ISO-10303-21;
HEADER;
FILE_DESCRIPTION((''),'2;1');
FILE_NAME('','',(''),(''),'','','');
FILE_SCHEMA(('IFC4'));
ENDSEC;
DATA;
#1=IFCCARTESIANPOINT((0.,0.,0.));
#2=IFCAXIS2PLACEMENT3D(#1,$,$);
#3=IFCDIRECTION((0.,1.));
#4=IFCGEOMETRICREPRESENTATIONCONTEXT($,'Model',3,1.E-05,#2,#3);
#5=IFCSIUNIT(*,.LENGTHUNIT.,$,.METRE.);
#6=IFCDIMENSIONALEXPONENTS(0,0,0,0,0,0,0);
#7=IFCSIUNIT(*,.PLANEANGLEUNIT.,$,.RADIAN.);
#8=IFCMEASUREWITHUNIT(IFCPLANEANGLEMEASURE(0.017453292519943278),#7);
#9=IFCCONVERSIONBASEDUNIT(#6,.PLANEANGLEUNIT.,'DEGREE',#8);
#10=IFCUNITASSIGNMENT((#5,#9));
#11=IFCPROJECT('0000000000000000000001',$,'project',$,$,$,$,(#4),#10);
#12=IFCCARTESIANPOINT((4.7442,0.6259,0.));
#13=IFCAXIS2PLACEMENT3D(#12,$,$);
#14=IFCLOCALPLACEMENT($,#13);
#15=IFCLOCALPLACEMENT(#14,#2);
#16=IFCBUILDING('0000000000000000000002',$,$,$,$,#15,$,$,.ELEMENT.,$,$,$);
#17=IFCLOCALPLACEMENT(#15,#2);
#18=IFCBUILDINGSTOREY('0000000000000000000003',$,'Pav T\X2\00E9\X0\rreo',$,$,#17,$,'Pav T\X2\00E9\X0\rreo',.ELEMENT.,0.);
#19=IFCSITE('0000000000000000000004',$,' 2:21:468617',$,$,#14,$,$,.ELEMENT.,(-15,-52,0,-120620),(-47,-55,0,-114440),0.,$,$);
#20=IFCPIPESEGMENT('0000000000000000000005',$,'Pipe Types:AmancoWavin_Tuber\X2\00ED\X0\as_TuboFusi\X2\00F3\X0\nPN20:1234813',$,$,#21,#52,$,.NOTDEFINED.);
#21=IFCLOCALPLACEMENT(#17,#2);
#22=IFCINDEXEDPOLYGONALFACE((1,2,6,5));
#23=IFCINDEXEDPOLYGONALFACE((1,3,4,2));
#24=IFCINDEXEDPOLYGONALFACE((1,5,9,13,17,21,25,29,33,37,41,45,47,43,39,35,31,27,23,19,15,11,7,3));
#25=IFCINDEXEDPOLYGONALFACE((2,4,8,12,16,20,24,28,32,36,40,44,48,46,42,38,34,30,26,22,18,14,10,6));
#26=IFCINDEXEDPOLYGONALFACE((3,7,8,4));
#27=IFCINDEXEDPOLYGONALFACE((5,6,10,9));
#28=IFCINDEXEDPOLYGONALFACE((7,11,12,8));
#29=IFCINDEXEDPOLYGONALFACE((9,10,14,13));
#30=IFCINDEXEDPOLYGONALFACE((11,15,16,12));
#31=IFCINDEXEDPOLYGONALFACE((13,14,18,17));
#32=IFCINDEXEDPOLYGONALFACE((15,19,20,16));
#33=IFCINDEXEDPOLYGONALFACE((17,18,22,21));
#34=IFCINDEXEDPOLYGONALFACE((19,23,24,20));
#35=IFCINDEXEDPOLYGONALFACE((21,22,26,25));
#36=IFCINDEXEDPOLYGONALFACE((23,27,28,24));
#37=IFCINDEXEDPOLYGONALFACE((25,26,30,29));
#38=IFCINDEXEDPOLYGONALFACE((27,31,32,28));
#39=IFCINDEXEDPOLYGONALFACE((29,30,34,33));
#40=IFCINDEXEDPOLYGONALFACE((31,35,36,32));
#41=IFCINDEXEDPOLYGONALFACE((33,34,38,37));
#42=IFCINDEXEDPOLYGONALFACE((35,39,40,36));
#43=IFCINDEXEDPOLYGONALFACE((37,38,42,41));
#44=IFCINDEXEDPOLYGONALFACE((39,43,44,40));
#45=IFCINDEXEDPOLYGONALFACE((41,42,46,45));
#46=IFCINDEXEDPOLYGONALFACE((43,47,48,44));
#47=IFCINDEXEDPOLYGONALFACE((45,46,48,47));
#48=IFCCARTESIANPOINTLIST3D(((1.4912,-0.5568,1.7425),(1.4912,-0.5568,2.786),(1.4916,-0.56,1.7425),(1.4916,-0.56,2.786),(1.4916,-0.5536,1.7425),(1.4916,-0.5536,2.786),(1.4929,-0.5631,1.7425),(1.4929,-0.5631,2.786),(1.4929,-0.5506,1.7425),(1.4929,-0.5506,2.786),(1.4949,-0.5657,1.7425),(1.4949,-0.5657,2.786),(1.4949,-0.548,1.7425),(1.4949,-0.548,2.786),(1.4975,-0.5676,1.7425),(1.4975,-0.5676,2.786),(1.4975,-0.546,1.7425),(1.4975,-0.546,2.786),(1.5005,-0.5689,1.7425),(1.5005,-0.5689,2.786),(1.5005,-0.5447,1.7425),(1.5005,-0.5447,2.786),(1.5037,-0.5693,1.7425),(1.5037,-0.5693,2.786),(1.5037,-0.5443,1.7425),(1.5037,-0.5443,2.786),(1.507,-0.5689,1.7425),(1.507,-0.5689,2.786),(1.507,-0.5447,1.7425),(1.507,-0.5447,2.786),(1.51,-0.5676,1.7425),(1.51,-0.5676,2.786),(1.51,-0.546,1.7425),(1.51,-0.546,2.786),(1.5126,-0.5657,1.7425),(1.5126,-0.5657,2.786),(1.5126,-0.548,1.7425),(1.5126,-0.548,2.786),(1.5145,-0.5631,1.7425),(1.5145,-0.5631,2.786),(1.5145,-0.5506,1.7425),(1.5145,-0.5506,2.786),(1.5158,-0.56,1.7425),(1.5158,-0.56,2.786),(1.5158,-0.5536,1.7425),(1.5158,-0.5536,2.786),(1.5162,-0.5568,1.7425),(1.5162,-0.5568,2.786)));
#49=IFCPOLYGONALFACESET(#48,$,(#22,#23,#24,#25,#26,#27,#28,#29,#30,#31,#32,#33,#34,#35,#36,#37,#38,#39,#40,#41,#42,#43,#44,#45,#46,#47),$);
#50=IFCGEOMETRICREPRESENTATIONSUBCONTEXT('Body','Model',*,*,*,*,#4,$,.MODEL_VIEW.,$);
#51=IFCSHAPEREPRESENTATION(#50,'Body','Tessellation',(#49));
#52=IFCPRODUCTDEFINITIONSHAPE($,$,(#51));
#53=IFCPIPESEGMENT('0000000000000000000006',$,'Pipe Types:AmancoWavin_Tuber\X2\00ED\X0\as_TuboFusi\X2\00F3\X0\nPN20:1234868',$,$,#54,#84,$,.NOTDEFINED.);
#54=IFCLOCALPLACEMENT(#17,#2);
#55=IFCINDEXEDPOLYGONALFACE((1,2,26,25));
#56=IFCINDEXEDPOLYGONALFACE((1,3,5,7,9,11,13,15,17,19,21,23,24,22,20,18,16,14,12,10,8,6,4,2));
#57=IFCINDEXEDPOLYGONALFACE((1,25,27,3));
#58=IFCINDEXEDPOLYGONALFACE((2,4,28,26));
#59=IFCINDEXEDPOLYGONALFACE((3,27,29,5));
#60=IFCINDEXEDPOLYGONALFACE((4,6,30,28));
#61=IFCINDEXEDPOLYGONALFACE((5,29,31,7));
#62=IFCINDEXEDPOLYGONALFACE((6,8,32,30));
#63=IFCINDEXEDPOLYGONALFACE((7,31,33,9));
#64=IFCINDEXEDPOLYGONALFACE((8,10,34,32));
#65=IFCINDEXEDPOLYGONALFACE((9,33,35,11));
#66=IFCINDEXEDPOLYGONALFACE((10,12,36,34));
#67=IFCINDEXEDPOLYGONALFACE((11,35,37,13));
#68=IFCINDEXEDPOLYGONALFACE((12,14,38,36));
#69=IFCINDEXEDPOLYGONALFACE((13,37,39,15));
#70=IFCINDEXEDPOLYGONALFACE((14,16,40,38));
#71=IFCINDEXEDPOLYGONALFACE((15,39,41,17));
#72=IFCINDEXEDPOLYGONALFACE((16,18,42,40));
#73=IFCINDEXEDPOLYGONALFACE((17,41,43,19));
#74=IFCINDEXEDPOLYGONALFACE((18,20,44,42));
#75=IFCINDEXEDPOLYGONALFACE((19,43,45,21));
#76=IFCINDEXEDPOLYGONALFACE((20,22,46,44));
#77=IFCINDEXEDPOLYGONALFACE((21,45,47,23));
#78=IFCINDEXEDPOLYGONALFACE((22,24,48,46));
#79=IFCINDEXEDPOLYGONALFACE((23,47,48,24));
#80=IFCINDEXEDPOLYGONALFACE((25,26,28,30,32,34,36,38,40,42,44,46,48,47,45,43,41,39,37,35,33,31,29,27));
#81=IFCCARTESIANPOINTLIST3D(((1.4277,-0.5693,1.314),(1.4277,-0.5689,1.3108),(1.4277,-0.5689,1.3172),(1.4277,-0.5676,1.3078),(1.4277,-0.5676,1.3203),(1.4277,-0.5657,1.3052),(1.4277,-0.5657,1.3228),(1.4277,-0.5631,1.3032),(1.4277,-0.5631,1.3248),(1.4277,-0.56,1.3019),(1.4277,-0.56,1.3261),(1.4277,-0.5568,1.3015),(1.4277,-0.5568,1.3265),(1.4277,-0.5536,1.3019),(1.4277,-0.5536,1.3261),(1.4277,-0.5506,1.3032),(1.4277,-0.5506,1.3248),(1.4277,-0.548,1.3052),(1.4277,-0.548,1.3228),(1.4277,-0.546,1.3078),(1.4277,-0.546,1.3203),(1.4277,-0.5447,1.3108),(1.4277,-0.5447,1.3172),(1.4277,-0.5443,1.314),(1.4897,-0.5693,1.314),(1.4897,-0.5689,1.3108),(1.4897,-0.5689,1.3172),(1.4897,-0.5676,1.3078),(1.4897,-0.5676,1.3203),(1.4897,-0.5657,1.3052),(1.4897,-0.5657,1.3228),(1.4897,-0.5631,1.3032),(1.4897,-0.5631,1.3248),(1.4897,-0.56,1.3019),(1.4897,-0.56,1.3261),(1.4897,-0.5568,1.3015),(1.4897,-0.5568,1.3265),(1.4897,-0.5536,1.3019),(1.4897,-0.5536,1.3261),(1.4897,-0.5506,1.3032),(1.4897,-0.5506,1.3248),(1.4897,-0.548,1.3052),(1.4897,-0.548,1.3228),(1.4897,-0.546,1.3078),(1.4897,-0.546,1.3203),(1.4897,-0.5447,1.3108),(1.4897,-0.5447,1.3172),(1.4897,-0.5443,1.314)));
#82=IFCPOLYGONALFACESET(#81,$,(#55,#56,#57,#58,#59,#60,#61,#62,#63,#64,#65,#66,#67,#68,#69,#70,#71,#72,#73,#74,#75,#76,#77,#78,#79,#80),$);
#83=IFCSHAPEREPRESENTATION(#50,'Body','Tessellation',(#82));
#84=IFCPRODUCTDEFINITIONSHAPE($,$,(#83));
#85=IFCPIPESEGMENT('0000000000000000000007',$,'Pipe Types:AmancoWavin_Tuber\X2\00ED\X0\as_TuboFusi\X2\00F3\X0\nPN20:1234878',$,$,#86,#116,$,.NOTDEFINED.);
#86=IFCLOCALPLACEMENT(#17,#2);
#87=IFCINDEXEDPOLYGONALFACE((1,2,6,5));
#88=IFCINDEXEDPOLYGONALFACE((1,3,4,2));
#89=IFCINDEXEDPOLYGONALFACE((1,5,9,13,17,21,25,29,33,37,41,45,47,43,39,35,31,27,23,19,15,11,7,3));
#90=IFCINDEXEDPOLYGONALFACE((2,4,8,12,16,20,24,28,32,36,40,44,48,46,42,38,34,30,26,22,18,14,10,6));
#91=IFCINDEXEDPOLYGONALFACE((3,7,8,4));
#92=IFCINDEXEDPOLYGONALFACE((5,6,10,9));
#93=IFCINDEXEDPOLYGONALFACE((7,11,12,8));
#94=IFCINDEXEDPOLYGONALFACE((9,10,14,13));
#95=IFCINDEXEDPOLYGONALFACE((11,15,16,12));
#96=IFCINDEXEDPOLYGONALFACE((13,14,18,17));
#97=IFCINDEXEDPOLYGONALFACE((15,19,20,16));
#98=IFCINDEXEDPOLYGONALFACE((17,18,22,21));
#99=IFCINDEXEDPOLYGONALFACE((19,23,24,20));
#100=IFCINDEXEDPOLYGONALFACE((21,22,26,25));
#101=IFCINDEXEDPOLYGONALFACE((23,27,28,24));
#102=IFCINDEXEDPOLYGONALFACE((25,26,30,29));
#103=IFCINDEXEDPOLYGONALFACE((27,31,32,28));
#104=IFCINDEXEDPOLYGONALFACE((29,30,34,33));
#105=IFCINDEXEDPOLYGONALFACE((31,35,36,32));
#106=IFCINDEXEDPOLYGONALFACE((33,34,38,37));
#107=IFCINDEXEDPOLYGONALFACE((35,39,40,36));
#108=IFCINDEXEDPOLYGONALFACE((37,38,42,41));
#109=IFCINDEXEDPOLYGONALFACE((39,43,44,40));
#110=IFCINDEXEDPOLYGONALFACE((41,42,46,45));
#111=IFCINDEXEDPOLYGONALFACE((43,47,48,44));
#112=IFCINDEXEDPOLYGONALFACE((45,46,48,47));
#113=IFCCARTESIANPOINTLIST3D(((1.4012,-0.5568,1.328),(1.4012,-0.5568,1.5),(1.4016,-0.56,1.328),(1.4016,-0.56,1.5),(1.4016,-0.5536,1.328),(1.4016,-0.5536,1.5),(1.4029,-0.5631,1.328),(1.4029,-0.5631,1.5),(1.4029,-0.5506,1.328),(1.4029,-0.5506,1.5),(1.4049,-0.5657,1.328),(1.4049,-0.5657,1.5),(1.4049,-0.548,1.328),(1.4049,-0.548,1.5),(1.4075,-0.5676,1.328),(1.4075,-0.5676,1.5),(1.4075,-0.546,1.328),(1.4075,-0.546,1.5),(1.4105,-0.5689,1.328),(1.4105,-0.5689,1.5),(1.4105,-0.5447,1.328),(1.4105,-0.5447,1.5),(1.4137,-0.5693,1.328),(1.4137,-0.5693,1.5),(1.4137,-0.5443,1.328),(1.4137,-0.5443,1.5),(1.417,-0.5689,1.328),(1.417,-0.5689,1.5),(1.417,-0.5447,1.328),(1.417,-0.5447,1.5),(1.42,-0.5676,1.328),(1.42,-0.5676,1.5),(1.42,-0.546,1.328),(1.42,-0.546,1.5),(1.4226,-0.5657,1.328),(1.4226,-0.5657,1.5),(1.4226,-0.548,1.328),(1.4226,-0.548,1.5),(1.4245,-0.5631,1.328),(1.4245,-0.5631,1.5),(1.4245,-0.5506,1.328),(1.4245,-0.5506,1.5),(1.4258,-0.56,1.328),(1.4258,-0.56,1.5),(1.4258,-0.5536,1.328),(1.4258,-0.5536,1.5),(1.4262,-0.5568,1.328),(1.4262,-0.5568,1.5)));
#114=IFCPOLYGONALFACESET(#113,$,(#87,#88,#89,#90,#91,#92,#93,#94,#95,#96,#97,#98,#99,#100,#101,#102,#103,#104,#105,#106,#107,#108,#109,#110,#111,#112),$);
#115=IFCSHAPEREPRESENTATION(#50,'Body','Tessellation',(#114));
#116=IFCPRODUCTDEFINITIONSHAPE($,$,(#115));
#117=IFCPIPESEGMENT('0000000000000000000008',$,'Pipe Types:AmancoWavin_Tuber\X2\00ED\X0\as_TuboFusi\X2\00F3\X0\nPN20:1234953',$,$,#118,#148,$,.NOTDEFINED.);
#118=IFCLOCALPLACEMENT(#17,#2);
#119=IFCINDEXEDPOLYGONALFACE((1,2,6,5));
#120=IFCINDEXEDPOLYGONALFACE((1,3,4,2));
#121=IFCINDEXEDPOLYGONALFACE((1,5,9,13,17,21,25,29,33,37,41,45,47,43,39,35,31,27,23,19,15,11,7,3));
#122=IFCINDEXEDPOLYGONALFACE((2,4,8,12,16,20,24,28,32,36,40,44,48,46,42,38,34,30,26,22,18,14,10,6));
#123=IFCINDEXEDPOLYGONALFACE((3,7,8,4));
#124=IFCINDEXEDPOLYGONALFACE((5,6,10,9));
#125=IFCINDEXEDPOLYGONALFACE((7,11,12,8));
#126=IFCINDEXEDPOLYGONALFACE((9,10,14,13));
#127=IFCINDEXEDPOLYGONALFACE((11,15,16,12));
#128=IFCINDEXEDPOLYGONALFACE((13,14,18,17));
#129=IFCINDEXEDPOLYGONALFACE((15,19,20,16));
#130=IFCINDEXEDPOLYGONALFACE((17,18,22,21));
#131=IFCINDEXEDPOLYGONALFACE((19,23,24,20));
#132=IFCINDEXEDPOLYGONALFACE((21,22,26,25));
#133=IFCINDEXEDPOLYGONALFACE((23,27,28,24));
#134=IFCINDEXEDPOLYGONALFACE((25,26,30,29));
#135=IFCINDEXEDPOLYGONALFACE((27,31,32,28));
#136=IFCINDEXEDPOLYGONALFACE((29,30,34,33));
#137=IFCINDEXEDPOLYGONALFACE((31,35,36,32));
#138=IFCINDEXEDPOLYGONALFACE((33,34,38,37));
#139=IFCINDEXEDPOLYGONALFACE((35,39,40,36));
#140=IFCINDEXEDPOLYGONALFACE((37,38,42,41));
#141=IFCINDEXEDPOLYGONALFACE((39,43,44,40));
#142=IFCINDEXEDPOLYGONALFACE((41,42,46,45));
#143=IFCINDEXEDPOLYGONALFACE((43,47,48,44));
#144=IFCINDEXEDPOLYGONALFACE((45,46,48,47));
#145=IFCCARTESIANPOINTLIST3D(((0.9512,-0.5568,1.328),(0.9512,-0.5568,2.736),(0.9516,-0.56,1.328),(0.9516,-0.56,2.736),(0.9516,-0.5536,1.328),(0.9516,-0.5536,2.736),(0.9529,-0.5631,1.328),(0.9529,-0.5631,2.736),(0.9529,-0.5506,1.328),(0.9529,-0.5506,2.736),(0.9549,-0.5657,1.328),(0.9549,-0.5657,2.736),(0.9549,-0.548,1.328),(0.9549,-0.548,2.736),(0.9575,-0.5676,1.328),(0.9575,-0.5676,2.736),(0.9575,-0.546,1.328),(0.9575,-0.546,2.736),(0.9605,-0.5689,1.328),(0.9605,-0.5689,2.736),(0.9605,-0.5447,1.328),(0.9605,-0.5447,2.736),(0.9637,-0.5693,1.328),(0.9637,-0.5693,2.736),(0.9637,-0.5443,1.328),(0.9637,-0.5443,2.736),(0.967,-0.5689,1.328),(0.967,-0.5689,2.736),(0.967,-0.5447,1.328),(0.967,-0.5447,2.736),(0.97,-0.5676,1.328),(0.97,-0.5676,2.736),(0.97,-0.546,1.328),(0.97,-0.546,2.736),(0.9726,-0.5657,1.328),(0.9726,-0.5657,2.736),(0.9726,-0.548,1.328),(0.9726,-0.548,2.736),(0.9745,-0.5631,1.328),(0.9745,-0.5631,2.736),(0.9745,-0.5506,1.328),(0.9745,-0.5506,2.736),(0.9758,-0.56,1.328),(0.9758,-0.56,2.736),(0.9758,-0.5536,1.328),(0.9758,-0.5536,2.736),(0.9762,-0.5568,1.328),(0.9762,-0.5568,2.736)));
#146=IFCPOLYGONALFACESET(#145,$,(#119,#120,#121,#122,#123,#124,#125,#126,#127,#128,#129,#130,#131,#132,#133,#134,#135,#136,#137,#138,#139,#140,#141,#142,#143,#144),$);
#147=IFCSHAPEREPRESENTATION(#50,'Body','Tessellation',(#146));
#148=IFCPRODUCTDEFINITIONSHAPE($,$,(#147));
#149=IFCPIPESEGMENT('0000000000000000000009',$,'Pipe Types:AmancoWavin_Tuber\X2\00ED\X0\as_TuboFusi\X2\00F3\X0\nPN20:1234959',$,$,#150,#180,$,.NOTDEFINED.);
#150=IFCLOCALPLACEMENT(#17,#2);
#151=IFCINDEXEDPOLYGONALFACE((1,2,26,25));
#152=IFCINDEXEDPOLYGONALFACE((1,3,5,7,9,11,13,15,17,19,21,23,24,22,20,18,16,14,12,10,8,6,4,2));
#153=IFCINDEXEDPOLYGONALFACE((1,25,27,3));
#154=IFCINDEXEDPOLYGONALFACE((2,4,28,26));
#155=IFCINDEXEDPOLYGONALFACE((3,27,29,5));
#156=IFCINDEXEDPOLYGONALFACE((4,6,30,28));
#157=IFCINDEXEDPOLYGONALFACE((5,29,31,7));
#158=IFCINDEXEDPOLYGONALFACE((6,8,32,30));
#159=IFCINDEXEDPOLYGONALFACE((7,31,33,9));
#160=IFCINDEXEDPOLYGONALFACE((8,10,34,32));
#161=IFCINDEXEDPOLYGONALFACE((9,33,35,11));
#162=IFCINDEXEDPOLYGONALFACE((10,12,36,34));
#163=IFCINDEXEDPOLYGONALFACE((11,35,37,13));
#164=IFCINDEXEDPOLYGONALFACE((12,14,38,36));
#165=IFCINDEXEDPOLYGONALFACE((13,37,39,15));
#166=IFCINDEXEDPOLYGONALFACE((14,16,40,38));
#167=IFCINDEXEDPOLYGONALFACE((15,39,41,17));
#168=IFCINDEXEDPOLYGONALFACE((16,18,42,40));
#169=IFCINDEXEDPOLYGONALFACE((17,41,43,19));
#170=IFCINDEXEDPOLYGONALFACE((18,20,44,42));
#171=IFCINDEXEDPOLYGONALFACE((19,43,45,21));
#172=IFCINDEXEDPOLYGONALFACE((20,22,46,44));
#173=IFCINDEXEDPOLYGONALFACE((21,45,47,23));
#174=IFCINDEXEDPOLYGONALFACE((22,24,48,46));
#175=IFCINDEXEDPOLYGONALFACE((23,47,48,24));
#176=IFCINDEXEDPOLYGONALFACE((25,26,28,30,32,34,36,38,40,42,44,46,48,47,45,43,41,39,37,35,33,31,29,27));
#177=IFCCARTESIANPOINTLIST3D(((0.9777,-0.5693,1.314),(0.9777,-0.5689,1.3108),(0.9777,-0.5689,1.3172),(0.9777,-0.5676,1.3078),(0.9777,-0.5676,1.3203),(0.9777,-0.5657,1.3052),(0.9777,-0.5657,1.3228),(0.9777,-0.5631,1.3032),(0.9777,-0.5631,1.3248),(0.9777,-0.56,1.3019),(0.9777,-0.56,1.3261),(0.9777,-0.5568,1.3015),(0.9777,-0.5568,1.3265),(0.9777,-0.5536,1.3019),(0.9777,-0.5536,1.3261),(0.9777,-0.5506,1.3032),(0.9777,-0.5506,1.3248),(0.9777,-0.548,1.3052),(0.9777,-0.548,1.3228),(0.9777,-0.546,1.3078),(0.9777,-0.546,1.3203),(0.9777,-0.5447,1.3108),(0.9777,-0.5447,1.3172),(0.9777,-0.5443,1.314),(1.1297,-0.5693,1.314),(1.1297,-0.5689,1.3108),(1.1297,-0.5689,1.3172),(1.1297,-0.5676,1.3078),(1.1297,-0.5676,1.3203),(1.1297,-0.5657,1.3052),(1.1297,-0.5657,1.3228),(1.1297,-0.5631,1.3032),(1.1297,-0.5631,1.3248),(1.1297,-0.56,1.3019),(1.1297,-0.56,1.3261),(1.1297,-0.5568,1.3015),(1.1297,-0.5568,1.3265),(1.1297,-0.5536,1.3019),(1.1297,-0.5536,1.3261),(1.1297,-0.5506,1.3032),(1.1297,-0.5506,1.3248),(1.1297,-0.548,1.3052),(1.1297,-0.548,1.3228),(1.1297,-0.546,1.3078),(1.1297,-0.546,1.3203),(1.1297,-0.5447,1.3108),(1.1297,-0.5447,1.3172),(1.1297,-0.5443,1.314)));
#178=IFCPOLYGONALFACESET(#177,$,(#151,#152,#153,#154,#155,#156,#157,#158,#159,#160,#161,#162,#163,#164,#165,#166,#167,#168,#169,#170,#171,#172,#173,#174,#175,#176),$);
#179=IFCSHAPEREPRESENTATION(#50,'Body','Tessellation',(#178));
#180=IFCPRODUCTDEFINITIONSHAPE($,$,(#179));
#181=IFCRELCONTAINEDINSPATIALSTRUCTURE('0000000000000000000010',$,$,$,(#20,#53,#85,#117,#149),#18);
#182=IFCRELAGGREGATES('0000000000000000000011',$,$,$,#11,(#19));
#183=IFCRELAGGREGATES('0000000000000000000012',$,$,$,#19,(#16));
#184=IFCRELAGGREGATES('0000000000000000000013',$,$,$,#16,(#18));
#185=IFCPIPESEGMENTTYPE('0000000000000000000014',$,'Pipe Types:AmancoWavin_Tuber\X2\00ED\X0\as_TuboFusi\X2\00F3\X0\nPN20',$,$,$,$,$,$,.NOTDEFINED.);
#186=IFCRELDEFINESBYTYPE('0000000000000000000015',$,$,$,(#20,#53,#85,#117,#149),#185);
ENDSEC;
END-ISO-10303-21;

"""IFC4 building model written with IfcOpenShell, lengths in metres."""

from ifc_helpers import new_model, entity, si_unit, converted_unit, direction, frame, origin, place, context, subcontext, project, spatial, arc, indexed_curve, outline, extrude, type_object, element, save


model = new_model("IFC4")

# Units and contexts
model_context = context("Model", 3, precision=1e-05, world=origin(), true_north=direction((0.0, 1.0)))
body_context = subcontext(model_context, "Body", "Model", "MODEL_VIEW")
ifc_project = project(units=[si_unit("LENGTHUNIT", "METRE"), converted_unit("PLANEANGLEUNIT", "DEGREE", entity("IfcPlaneAngleMeasure", 0.017453292519943278), si_unit("PLANEANGLEUNIT", "RADIAN"), dimensions=[0, 0, 0, 0, 0, 0, 0])], contexts=[model_context])

# Site, building, storey
site_placement = place(None, frame((4.7442, 0.6259, 0.0)))
site = spatial("IfcSite", under=ifc_project, at=site_placement, Name=" 2:21:468617", CompositionType="ELEMENT", RefLatitude=(-15, -52, 0, -120620), RefLongitude=(-47, -55, 0, -114440), RefElevation=0.0)
building_placement = place(site_placement, origin())
building = spatial("IfcBuilding", under=site, at=building_placement, CompositionType="ELEMENT")
storey_placement = place(building_placement, origin())
storey = spatial("IfcBuildingStorey", under=building, at=storey_placement, Name="Pav Térreo", LongName="Pav Térreo", CompositionType="ELEMENT", Elevation=0.0)

# Pipe segments
pipe_segment_type_1 = type_object("IfcPipeSegmentType", Name="Pipe Types:AmancoWavin_Tuberías_TuboFusiónPN20", PredefinedType="NOTDEFINED")
pipe_segment_1_placement = place(storey_placement, origin())
element("IfcPipeSegment", 1, at=pipe_segment_1_placement, inside=storey, type_object=pipe_segment_type_1, Name="Pipe Types:AmancoWavin_Tuberías_TuboFusiónPN20:1234813", PredefinedType="NOTDEFINED", context=body_context, shape_type="SweptSolid", body=[
    extrude(outline(indexed_curve([(0.0125, 0.0), (0.0088, 0.0088), (0.0, 0.0125), (-0.0088, 0.0088), (-0.0125, 0.0), (-0.0088, -0.0088), (0.0, -0.0125), (0.0088, -0.0088)], segments=[arc(1, 2, 3), arc(3, 4, 5), arc(5, 6, 7), arc(7, 8, 1)], self_intersect=False)), frame((1.5037, -0.5568, 1.7425)), (0.0, 0.0, 1.0), 1.0435),
])
pipe_segment_2_placement = place(storey_placement, origin())
element("IfcPipeSegment", 2, at=pipe_segment_2_placement, inside=storey, type_object=pipe_segment_type_1, Name="Pipe Types:AmancoWavin_Tuberías_TuboFusiónPN20:1234868", PredefinedType="NOTDEFINED", context=body_context, shape_type="SweptSolid", body=[
    extrude(outline(indexed_curve([(0.0125, 0.0), (0.0088, 0.0088), (0.0, 0.0125), (-0.0088, 0.0088), (-0.0125, 0.0), (-0.0088, -0.0088), (0.0, -0.0125), (0.0088, -0.0088)], segments=[arc(1, 2, 3), arc(3, 4, 5), arc(5, 6, 7), arc(7, 8, 1)], self_intersect=False)), frame((1.4277, -0.5568, 1.314), z_axis=(1.0, 0.0, 0.0), x_axis=(0.0, 1.0, 0.0)), (0.0, 0.0, 1.0), 0.062),
])
pipe_segment_3_placement = place(storey_placement, origin())
element("IfcPipeSegment", 3, at=pipe_segment_3_placement, inside=storey, type_object=pipe_segment_type_1, Name="Pipe Types:AmancoWavin_Tuberías_TuboFusiónPN20:1234878", PredefinedType="NOTDEFINED", context=body_context, shape_type="SweptSolid", body=[
    extrude(outline(indexed_curve([(0.0125, 0.0), (0.0088, 0.0088), (0.0, 0.0125), (-0.0088, 0.0088), (-0.0125, 0.0), (-0.0088, -0.0088), (0.0, -0.0125), (0.0088, -0.0088)], segments=[arc(1, 2, 3), arc(3, 4, 5), arc(5, 6, 7), arc(7, 8, 1)], self_intersect=False)), frame((1.4137, -0.5568, 1.328), z_axis=(0.0, 0.0, 1.0), x_axis=(-1.0, 0.0, 0.0)), (0.0, 0.0, 1.0), 0.172),
])
pipe_segment_4_placement = place(storey_placement, origin())
element("IfcPipeSegment", 4, at=pipe_segment_4_placement, inside=storey, type_object=pipe_segment_type_1, Name="Pipe Types:AmancoWavin_Tuberías_TuboFusiónPN20:1234953", PredefinedType="NOTDEFINED", context=body_context, shape_type="SweptSolid", body=[
    extrude(outline(indexed_curve([(0.0125, 0.0), (0.0088, 0.0088), (0.0, 0.0125), (-0.0088, 0.0088), (-0.0125, 0.0), (-0.0088, -0.0088), (0.0, -0.0125), (0.0088, -0.0088)], segments=[arc(1, 2, 3), arc(3, 4, 5), arc(5, 6, 7), arc(7, 8, 1)], self_intersect=False)), frame((0.9637, -0.5568, 1.328)), (0.0, 0.0, 1.0), 1.408),
])
pipe_segment_5_placement = place(storey_placement, origin())
element("IfcPipeSegment", 5, at=pipe_segment_5_placement, inside=storey, type_object=pipe_segment_type_1, Name="Pipe Types:AmancoWavin_Tuberías_TuboFusiónPN20:1234959", PredefinedType="NOTDEFINED", context=body_context, shape_type="SweptSolid", body=[
    extrude(outline(indexed_curve([(0.0125, 0.0), (0.0088, 0.0088), (0.0, 0.0125), (-0.0088, 0.0088), (-0.0125, 0.0), (-0.0088, -0.0088), (0.0, -0.0125), (0.0088, -0.0088)], segments=[arc(1, 2, 3), arc(3, 4, 5), arc(5, 6, 7), arc(7, 8, 1)], self_intersect=False)), frame((0.9777, -0.5568, 1.314), z_axis=(1.0, 0.0, 0.0), x_axis=(0.0, -1.0, 0.0)), (0.0, 0.0, 1.0), 0.152),
])

save(model, "model.ifc")
